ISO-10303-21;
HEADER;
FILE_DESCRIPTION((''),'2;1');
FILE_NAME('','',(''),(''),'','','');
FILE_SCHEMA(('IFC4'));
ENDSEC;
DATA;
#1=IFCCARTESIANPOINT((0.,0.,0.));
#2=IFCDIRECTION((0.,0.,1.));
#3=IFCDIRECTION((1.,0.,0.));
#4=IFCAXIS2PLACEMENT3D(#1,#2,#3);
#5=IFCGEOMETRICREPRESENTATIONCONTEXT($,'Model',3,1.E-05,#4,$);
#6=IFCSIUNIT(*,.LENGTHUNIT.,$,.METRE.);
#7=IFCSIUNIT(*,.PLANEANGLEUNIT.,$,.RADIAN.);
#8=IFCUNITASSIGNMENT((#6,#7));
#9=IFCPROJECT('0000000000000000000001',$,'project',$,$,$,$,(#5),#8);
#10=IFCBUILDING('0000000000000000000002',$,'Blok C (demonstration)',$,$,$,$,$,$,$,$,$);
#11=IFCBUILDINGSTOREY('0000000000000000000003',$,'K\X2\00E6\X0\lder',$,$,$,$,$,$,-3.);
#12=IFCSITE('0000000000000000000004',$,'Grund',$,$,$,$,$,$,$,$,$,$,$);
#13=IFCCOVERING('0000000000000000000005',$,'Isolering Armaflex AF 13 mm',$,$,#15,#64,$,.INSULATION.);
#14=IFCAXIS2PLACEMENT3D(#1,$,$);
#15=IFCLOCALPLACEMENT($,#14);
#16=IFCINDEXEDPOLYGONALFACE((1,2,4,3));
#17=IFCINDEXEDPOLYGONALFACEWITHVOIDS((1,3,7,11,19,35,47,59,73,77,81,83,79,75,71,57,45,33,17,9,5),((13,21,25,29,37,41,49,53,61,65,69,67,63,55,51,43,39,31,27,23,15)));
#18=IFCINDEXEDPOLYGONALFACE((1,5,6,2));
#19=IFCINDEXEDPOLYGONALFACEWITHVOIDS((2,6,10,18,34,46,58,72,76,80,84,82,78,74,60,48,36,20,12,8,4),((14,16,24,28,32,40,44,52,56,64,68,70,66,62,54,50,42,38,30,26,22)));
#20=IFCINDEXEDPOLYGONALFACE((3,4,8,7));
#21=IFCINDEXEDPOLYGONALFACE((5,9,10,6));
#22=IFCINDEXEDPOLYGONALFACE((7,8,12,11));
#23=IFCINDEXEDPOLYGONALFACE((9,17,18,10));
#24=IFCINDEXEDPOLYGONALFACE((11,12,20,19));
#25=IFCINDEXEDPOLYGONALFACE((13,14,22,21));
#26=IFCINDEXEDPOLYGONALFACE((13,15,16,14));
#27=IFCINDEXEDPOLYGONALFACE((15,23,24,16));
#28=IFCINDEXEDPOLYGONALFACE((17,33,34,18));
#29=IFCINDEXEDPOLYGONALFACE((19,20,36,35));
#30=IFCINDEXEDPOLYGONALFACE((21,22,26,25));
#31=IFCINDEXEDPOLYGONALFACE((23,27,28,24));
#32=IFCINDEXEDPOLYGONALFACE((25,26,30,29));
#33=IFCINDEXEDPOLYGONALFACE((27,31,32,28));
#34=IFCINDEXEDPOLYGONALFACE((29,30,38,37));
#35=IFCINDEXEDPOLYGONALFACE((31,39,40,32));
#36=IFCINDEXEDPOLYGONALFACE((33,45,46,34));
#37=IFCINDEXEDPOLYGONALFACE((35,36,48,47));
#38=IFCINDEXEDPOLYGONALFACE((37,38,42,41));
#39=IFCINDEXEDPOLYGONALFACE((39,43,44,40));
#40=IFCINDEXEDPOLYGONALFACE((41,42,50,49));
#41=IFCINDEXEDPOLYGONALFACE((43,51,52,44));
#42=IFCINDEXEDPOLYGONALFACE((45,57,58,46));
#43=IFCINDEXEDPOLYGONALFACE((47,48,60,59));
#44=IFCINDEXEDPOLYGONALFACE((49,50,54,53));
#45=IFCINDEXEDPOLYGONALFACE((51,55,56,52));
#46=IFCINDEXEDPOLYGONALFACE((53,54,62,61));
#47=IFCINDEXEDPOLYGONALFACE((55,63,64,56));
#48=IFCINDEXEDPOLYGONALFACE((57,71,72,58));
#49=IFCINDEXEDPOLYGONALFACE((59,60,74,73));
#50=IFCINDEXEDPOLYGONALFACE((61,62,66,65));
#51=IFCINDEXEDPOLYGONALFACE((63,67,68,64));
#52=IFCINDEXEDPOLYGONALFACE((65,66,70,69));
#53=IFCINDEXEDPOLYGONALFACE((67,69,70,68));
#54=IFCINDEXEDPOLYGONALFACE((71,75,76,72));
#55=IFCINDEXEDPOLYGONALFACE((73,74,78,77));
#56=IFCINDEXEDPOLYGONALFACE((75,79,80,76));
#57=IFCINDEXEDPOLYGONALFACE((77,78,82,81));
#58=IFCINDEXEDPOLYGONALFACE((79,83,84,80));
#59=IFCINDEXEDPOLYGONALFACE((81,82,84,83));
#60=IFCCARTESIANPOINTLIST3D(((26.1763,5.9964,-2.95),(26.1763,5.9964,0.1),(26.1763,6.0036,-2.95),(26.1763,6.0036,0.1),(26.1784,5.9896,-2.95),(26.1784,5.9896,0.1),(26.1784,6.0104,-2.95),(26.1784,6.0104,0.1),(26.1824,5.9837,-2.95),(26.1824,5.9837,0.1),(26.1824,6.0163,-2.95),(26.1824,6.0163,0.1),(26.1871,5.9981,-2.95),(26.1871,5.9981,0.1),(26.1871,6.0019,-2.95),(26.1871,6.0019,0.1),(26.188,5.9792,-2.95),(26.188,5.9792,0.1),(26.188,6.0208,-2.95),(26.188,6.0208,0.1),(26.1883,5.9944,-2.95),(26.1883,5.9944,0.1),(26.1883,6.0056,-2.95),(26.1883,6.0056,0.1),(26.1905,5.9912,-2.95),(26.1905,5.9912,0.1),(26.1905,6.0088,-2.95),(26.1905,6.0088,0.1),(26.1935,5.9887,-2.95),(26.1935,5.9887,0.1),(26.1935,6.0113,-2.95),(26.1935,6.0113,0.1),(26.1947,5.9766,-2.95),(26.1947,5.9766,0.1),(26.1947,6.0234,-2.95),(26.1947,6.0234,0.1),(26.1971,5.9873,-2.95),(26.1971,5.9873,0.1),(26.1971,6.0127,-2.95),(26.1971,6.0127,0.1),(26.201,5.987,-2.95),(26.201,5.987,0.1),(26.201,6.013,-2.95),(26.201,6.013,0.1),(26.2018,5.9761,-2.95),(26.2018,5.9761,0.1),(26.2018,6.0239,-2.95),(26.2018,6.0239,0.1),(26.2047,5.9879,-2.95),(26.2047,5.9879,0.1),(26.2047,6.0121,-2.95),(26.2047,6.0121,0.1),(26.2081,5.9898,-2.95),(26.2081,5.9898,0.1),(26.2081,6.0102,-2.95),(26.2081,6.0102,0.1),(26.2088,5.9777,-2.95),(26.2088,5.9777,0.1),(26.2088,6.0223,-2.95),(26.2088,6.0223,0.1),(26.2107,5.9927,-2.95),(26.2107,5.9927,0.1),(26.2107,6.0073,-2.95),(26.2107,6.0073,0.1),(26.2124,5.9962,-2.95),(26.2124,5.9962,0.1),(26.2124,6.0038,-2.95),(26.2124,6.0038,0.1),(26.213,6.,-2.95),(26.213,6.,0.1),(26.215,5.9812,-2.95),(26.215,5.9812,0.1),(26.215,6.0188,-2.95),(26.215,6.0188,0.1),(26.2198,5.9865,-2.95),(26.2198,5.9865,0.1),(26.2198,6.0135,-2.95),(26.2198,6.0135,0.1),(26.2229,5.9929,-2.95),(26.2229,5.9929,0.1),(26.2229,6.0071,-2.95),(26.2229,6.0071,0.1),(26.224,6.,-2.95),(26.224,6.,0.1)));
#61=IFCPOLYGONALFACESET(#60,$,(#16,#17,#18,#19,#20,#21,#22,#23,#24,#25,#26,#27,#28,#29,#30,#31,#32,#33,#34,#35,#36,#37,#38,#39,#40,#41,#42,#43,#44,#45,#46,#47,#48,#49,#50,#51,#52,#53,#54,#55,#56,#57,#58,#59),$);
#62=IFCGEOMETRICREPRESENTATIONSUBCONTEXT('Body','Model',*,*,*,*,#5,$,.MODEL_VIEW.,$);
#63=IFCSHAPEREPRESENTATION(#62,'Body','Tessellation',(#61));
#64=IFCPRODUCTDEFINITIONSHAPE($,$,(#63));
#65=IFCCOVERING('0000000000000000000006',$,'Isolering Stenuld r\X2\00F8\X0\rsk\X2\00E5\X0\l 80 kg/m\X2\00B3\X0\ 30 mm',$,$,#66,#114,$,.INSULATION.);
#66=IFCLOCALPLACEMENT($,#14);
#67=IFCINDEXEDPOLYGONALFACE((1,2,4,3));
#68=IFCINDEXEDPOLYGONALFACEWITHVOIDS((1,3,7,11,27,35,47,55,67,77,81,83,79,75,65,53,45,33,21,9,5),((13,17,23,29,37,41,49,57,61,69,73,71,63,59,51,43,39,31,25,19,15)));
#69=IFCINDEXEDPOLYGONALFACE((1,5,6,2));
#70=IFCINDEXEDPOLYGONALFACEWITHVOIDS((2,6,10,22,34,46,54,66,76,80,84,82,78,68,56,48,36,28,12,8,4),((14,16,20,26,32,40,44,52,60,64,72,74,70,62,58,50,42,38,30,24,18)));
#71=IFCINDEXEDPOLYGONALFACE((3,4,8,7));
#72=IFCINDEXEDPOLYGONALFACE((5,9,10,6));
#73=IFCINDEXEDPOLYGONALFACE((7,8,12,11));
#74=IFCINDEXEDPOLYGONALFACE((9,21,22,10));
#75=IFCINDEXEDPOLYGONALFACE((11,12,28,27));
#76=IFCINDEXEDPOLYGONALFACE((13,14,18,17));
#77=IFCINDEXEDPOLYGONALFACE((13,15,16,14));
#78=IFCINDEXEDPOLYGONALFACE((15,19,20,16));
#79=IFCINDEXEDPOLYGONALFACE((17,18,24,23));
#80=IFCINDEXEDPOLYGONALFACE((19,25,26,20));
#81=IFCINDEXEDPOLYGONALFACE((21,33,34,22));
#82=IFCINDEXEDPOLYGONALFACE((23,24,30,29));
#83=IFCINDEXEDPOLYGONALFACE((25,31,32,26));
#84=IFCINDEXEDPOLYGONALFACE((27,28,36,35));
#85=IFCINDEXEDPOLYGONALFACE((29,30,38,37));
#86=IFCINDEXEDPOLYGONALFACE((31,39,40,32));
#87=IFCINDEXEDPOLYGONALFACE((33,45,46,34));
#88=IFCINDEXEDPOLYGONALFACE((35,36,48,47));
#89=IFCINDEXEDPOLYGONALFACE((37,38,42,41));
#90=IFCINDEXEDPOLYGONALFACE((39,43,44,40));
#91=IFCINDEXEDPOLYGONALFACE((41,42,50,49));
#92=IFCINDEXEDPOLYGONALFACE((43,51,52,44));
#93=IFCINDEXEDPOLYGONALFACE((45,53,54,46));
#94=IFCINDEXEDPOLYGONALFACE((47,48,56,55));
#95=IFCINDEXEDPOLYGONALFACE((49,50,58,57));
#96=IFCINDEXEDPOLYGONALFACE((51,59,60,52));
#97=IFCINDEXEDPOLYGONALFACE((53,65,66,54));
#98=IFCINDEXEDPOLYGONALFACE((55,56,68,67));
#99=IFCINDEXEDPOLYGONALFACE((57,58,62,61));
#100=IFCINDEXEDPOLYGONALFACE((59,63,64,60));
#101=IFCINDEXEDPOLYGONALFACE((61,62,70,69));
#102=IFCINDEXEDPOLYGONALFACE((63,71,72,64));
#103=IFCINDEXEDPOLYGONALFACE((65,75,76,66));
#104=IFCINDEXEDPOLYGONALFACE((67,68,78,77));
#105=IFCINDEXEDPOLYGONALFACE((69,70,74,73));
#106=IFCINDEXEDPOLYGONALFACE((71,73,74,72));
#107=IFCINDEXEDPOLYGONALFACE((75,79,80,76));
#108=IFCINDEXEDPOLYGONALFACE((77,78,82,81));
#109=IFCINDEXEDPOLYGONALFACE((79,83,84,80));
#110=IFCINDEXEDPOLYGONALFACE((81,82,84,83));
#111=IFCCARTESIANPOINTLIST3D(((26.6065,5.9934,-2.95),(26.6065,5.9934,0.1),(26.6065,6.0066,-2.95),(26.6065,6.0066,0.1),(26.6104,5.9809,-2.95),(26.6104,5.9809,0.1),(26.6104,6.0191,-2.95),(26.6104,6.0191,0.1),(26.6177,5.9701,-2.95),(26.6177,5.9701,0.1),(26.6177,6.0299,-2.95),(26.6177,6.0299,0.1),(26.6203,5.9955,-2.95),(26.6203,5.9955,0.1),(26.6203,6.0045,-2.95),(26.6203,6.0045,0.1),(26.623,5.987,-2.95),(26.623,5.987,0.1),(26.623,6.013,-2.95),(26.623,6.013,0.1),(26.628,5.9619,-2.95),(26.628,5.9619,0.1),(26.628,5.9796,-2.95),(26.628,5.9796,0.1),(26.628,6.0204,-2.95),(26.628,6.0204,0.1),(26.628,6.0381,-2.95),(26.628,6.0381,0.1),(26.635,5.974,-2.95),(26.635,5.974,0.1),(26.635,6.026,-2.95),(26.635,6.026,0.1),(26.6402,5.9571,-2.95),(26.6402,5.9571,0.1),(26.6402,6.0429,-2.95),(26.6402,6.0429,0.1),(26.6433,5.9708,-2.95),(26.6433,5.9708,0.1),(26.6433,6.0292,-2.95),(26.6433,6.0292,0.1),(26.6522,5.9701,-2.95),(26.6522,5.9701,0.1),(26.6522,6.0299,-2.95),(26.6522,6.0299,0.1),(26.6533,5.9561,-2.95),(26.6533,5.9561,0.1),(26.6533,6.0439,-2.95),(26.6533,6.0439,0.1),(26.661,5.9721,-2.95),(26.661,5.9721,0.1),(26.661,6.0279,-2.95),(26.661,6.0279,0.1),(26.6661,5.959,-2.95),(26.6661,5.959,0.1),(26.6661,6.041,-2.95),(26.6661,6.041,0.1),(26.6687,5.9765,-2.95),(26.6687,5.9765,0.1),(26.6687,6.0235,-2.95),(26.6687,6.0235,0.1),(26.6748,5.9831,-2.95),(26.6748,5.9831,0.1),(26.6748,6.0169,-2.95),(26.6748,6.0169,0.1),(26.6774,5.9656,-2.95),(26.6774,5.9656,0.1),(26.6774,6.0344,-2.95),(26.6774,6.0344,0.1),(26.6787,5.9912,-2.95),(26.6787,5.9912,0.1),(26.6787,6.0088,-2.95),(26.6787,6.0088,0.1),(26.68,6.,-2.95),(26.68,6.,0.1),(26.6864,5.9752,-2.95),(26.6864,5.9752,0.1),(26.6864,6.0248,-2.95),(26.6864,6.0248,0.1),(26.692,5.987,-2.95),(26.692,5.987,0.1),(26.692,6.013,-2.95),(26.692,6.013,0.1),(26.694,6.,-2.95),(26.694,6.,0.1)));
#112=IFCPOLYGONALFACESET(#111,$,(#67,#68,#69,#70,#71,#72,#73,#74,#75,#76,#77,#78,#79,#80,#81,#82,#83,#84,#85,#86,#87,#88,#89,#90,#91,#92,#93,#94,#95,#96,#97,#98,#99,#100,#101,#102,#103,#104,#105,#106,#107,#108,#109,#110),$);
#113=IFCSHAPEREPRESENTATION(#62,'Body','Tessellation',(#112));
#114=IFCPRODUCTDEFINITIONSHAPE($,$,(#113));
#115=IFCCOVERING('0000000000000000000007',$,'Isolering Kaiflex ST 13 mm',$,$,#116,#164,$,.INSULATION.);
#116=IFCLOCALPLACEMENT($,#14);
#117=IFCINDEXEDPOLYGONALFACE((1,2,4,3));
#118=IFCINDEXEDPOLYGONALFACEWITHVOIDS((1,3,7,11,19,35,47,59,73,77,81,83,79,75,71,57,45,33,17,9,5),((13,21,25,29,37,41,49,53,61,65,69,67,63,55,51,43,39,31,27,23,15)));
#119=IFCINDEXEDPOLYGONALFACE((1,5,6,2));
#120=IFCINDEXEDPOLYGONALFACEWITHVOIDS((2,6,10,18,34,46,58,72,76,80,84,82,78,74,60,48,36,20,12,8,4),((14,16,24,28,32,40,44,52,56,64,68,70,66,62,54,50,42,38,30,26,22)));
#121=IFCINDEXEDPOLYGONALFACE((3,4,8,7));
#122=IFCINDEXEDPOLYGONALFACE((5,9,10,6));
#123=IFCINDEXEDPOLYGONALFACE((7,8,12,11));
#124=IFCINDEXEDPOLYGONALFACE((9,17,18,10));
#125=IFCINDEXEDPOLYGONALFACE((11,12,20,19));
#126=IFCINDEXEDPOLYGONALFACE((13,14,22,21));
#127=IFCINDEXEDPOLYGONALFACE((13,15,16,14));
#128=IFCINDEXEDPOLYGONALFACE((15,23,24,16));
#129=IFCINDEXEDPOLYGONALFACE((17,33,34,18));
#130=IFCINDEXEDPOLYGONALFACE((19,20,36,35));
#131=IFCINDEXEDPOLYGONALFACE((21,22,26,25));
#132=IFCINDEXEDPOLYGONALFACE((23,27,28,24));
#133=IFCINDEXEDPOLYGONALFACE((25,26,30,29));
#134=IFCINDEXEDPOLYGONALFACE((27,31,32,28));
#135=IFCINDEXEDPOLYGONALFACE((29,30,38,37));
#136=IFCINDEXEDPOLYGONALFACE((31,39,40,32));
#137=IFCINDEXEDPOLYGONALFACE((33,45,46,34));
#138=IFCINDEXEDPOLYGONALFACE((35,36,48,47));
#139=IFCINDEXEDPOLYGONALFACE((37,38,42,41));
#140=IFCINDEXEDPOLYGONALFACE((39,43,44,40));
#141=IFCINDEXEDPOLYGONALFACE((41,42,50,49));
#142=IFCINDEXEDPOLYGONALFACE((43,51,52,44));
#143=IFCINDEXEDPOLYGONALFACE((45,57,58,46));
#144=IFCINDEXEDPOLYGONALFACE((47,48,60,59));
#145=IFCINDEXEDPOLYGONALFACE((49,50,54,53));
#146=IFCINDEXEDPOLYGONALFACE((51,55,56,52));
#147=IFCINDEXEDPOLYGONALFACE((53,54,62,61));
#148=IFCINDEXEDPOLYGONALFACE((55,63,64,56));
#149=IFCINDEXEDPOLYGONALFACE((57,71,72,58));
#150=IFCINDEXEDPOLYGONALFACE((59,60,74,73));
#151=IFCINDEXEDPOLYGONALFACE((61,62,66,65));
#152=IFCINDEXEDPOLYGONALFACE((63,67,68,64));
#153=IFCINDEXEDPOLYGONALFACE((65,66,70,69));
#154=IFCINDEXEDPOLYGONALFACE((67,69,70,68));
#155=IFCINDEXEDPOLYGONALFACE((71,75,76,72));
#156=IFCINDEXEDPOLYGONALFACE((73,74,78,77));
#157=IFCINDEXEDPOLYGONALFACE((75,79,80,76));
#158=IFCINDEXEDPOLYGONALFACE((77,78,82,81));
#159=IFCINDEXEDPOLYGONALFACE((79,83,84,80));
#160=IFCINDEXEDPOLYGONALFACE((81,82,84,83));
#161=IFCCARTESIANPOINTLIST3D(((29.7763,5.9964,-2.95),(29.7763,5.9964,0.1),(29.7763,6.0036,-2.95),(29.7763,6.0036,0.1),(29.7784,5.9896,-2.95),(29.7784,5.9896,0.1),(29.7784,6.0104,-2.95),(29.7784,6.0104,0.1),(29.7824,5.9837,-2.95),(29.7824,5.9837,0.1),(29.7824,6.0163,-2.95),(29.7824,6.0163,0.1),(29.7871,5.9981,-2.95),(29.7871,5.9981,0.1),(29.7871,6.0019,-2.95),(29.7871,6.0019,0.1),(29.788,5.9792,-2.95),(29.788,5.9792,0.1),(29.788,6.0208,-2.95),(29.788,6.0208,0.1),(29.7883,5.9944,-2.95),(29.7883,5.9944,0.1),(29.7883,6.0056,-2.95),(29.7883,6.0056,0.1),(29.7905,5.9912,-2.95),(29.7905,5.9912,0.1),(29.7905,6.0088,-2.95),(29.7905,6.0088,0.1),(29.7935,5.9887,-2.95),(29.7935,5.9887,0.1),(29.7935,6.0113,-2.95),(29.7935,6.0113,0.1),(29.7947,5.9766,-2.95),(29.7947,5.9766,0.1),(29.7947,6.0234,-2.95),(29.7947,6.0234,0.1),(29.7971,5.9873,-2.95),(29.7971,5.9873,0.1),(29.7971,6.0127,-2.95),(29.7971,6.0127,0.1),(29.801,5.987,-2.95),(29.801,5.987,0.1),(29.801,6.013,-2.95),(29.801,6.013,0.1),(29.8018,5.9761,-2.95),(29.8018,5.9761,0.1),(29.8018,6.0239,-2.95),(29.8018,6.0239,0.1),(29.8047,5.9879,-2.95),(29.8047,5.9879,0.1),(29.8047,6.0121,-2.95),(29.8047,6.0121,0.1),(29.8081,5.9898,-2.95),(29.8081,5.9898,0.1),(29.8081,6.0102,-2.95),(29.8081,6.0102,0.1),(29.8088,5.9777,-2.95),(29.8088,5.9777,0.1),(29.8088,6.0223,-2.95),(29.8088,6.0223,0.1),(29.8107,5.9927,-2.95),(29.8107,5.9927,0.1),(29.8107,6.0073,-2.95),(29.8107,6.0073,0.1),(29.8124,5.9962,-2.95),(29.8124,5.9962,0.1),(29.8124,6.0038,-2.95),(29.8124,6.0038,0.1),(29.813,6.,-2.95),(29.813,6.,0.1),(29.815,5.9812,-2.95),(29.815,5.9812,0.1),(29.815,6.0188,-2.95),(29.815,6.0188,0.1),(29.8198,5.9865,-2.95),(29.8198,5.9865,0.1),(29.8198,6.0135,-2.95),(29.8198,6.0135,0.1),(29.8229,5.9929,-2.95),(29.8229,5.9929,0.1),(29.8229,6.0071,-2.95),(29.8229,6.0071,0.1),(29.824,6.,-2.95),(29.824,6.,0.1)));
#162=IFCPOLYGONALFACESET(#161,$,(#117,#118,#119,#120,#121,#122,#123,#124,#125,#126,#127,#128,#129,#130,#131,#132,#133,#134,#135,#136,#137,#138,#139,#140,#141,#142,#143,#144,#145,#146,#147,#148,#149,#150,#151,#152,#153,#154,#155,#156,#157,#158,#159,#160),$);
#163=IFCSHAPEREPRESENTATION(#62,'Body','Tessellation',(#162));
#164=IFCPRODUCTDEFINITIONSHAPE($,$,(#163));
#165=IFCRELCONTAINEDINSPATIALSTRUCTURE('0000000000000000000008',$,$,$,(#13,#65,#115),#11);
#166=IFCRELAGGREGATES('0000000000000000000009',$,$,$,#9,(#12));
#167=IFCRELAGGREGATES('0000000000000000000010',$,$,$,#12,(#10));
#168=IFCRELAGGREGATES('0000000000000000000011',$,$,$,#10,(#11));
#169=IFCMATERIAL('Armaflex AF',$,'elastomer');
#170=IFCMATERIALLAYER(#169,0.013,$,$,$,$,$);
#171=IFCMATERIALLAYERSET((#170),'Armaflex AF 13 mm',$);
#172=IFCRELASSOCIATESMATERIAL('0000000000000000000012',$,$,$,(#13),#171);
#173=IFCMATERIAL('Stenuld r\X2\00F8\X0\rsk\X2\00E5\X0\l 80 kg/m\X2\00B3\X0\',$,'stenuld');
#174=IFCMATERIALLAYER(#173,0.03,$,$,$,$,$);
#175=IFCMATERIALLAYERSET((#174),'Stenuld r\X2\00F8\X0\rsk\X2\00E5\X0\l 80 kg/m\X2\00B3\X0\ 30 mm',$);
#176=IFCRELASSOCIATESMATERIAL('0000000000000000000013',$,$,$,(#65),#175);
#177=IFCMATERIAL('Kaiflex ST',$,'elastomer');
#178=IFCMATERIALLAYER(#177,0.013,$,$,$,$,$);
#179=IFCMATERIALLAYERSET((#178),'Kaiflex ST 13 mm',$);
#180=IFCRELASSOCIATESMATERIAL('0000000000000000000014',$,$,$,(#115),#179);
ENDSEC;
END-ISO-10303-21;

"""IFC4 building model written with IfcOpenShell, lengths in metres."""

from ifc_helpers import new_model, si_unit, frame, origin_with_axes, place, context, subcontext, project, spatial, hollow_circle, extrude, material, layer, layer_set, element, save


model = new_model("IFC4")

# Units and contexts
model_context = context("Model", 3, precision=1e-05, world=origin_with_axes())
body_context = subcontext(model_context, "Body", "Model", "MODEL_VIEW")
ifc_project = project(units=[si_unit("LENGTHUNIT", "METRE"), si_unit("PLANEANGLEUNIT", "RADIAN")], contexts=[model_context])

# Site, building, storey
site = spatial("IfcSite", under=ifc_project, Name="Grund")
building = spatial("IfcBuilding", under=site, Name="Blok C (demonstration)")
storey = spatial("IfcBuildingStorey", under=building, Name="Kælder", Elevation=-3.0)

# Coverings
ifc_material_1 = material(Name="Armaflex AF", Category="elastomer")
ifc_layer_1 = layer(ifc_material_1, 0.013)
ifc_layer_set_1 = layer_set([ifc_layer_1], Name="Armaflex AF 13 mm")
covering_1_placement = place(None, origin_with_axes())
element("IfcCovering", 1, at=covering_1_placement, inside=storey, material=ifc_layer_set_1, Name="Isolering Armaflex AF 13 mm", PredefinedType="INSULATION", context=body_context, shape_type="SweptSolid", body=[
    extrude(hollow_circle(Radius=0.024, WallThickness=0.011), frame((26.2, 6.0, -2.95), z_axis=(0.0, 0.0, 1.0), x_axis=(1.0, 0.0, 0.0)), (0.0, 0.0, 1.0), 3.05),
])
ifc_material_2 = material(Name="Stenuld rørskål 80 kg/m³", Category="stenuld")
ifc_layer_2 = layer(ifc_material_2, 0.03)
ifc_layer_set_2 = layer_set([ifc_layer_2], Name="Stenuld rørskål 80 kg/m³ 30 mm")
covering_2_placement = place(None, origin_with_axes())
element("IfcCovering", 2, at=covering_2_placement, inside=storey, material=ifc_layer_set_2, Name="Isolering Stenuld rørskål 80 kg/m³ 30 mm", PredefinedType="INSULATION", context=body_context, shape_type="SweptSolid", body=[
    extrude(hollow_circle(Radius=0.044, WallThickness=0.014), frame((26.65, 6.0, -2.95), z_axis=(0.0, 0.0, 1.0), x_axis=(1.0, 0.0, 0.0)), (0.0, 0.0, 1.0), 3.05),
])
ifc_material_3 = material(Name="Kaiflex ST", Category="elastomer")
ifc_layer_3 = layer(ifc_material_3, 0.013)
ifc_layer_set_3 = layer_set([ifc_layer_3], Name="Kaiflex ST 13 mm")
covering_3_placement = place(None, origin_with_axes())
element("IfcCovering", 3, at=covering_3_placement, inside=storey, material=ifc_layer_set_3, Name="Isolering Kaiflex ST 13 mm", PredefinedType="INSULATION", context=body_context, shape_type="SweptSolid", body=[
    extrude(hollow_circle(Radius=0.024, WallThickness=0.011), frame((29.8, 6.0, -2.95), z_axis=(0.0, 0.0, 1.0), x_axis=(1.0, 0.0, 0.0)), (0.0, 0.0, 1.0), 3.05),
])

save(model, "model.ifc")
